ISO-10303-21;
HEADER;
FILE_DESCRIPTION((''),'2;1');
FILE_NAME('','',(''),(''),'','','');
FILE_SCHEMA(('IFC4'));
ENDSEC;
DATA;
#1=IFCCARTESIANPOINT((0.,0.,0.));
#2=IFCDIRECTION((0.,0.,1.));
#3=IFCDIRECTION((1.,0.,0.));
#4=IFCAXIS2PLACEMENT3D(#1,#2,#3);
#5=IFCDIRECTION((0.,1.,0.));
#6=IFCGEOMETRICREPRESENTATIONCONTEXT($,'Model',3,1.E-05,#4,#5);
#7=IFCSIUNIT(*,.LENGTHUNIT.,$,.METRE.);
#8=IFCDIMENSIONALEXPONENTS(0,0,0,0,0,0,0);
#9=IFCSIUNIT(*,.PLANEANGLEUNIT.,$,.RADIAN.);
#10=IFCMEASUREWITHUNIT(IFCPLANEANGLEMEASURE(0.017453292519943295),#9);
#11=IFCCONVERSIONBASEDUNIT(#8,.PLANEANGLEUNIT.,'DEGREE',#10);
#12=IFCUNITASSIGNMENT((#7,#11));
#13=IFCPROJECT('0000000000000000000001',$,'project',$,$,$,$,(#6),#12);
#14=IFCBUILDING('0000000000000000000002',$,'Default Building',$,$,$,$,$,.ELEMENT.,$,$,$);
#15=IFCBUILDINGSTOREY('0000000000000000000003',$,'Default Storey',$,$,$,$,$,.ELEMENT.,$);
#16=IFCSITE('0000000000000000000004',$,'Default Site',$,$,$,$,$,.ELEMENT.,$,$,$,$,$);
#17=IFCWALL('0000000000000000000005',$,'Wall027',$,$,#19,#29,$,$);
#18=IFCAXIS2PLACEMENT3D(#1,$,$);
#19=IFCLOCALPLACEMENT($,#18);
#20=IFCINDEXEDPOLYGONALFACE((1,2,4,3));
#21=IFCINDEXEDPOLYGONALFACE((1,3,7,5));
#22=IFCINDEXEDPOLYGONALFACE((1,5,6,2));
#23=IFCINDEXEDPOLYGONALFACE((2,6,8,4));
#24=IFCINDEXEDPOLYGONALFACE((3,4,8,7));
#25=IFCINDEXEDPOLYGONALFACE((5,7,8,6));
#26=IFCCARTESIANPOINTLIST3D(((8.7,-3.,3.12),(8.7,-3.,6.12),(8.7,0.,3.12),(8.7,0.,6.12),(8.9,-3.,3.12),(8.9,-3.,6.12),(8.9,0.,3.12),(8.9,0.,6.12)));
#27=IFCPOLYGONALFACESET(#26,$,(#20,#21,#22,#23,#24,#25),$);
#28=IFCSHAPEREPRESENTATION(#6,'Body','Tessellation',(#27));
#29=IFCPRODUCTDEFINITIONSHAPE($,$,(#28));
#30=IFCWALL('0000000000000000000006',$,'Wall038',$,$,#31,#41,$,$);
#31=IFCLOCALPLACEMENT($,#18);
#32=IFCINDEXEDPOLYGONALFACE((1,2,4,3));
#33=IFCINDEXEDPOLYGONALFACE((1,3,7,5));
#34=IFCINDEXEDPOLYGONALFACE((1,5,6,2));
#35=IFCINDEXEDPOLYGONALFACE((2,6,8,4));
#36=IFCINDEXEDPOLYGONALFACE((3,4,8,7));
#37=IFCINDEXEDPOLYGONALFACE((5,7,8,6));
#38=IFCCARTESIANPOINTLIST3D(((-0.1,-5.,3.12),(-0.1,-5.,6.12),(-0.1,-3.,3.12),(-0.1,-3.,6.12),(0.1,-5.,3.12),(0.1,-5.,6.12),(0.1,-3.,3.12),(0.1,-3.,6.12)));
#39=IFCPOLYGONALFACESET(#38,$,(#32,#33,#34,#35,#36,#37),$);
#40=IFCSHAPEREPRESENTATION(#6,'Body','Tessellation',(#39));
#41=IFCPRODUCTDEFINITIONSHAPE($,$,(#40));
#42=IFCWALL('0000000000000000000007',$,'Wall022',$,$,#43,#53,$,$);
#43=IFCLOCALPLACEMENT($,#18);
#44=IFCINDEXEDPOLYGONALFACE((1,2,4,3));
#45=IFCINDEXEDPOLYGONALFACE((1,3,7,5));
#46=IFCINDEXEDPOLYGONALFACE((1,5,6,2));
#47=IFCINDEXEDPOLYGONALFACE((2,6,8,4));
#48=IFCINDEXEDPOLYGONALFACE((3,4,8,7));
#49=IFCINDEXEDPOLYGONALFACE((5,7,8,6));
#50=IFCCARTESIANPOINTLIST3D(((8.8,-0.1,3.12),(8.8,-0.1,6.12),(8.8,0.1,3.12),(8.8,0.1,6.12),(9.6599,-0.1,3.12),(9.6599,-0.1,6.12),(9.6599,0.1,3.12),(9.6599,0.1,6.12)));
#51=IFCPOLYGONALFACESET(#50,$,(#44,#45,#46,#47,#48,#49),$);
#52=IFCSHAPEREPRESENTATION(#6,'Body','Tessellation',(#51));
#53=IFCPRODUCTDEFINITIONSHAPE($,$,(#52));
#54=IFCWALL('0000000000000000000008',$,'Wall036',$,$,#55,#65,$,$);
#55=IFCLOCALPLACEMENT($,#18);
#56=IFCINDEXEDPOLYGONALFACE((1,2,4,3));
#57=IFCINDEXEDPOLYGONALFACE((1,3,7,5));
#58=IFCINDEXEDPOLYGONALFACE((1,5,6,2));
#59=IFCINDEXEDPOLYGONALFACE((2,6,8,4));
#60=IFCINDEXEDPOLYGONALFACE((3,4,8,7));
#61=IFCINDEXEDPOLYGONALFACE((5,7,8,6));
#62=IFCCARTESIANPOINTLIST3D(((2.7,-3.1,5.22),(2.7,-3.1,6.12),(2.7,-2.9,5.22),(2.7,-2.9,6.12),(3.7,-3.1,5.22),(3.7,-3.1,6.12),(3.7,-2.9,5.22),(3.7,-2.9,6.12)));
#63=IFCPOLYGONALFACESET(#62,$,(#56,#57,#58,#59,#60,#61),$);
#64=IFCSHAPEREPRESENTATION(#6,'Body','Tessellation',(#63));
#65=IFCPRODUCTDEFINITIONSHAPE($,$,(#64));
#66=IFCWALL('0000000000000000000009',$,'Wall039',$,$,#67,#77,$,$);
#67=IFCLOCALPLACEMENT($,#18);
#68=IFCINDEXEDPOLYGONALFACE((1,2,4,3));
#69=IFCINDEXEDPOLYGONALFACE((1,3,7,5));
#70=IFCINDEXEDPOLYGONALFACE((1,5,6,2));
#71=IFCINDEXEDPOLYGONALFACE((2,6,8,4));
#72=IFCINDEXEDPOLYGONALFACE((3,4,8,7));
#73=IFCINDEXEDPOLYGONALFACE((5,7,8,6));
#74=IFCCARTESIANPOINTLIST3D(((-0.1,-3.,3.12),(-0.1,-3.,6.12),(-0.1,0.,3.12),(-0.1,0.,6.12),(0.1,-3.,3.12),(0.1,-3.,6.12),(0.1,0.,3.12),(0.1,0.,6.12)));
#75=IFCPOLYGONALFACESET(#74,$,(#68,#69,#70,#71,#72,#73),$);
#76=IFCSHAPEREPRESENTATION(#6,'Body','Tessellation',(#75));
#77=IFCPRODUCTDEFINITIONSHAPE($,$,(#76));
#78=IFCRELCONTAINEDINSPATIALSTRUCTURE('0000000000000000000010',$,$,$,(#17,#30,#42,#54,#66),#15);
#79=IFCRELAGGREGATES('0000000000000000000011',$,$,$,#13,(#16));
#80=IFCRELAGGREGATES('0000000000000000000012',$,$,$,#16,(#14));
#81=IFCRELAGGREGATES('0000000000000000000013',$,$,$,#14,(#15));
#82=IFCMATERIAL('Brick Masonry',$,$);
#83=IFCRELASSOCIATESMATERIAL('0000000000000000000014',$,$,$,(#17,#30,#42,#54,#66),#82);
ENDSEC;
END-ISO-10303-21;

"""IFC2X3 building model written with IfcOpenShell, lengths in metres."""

from ifc_helpers import new_model, entity, si_unit, converted_unit, direction, frame, frame_2d, origin_with_axes, place, context, project, spatial, rectangle, extrude, material, element, save


model = new_model("IFC2X3")

# Units and contexts
model_context = context("Model", 3, precision=1e-05, world=origin_with_axes(), true_north=direction((0.0, 1.0, 0.0)))
ifc_project = project(units=[si_unit("LENGTHUNIT", "METRE"), converted_unit("PLANEANGLEUNIT", "DEGREE", entity("IfcPlaneAngleMeasure", 0.017453292519943295), si_unit("PLANEANGLEUNIT", "RADIAN"), dimensions=[0, 0, 0, 0, 0, 0, 0])], contexts=[model_context])

# Site, building, storey
site = spatial("IfcSite", under=ifc_project, Name="Default Site", CompositionType="ELEMENT")
building = spatial("IfcBuilding", under=site, Name="Default Building", CompositionType="ELEMENT")
storey = spatial("IfcBuildingStorey", under=building, Name="Default Storey", CompositionType="ELEMENT")

# Shared definitions
placement = place(None, origin_with_axes())

# Walls
ifc_material_1 = material(Name="Brick Masonry")
element("IfcWall", 1, at=placement, inside=storey, material=ifc_material_1, Name="Wall027", context=model_context, shape_type="SweptSolid", body=[
    extrude(rectangle(XDim=3.0, YDim=0.2, at=frame_2d((0.0, 0.0), x_axis=(0.0, -1.0, 0.0))), frame((8.8, -1.5, 3.12), z_axis=(0.0, 0.0, 1.0), x_axis=(1.0, 0.0, 0.0)), (0.0, 0.0, 1.0), 3.0),
])
element("IfcWall", 2, at=placement, inside=storey, material=ifc_material_1, Name="Wall038", context=model_context, shape_type="SweptSolid", body=[
    extrude(rectangle(XDim=2.0, YDim=0.2, at=frame_2d((0.0, 0.0), x_axis=(0.0, -1.0, 0.0))), frame((0.0, -4.0, 3.12), z_axis=(0.0, 0.0, 1.0), x_axis=(1.0, 0.0, 0.0)), (0.0, 0.0, 1.0), 3.0),
])
element("IfcWall", 3, at=placement, inside=storey, material=ifc_material_1, Name="Wall022", context=model_context, shape_type="SweptSolid", body=[
    extrude(rectangle(XDim=0.8599, YDim=0.2, at=frame_2d((0.0, 0.0), x_axis=(1.0, 0.0, 0.0))), frame((9.2299, 0.0, 3.12), z_axis=(0.0, 0.0, 1.0), x_axis=(1.0, 0.0, 0.0)), (0.0, 0.0, 1.0), 3.0),
])
element("IfcWall", 4, at=placement, inside=storey, material=ifc_material_1, Name="Wall036", context=model_context, shape_type="SweptSolid", body=[
    extrude(rectangle(XDim=1.0, YDim=0.2, at=frame_2d((0.0, 0.0), x_axis=(1.0, 0.0, 0.0))), frame((3.2, -3.0, 5.22), z_axis=(0.0, 0.0, 1.0), x_axis=(1.0, 0.0, 0.0)), (0.0, 0.0, 1.0), 0.9),
])
element("IfcWall", 5, at=placement, inside=storey, material=ifc_material_1, Name="Wall039", context=model_context, shape_type="SweptSolid", body=[
    extrude(rectangle(XDim=3.0, YDim=0.2, at=frame_2d((0.0, 0.0), x_axis=(0.0, -1.0, 0.0))), frame((0.0, -1.5, 3.12), z_axis=(0.0, 0.0, 1.0), x_axis=(1.0, 0.0, 0.0)), (0.0, 0.0, 1.0), 3.0),
])

save(model, "model.ifc")
